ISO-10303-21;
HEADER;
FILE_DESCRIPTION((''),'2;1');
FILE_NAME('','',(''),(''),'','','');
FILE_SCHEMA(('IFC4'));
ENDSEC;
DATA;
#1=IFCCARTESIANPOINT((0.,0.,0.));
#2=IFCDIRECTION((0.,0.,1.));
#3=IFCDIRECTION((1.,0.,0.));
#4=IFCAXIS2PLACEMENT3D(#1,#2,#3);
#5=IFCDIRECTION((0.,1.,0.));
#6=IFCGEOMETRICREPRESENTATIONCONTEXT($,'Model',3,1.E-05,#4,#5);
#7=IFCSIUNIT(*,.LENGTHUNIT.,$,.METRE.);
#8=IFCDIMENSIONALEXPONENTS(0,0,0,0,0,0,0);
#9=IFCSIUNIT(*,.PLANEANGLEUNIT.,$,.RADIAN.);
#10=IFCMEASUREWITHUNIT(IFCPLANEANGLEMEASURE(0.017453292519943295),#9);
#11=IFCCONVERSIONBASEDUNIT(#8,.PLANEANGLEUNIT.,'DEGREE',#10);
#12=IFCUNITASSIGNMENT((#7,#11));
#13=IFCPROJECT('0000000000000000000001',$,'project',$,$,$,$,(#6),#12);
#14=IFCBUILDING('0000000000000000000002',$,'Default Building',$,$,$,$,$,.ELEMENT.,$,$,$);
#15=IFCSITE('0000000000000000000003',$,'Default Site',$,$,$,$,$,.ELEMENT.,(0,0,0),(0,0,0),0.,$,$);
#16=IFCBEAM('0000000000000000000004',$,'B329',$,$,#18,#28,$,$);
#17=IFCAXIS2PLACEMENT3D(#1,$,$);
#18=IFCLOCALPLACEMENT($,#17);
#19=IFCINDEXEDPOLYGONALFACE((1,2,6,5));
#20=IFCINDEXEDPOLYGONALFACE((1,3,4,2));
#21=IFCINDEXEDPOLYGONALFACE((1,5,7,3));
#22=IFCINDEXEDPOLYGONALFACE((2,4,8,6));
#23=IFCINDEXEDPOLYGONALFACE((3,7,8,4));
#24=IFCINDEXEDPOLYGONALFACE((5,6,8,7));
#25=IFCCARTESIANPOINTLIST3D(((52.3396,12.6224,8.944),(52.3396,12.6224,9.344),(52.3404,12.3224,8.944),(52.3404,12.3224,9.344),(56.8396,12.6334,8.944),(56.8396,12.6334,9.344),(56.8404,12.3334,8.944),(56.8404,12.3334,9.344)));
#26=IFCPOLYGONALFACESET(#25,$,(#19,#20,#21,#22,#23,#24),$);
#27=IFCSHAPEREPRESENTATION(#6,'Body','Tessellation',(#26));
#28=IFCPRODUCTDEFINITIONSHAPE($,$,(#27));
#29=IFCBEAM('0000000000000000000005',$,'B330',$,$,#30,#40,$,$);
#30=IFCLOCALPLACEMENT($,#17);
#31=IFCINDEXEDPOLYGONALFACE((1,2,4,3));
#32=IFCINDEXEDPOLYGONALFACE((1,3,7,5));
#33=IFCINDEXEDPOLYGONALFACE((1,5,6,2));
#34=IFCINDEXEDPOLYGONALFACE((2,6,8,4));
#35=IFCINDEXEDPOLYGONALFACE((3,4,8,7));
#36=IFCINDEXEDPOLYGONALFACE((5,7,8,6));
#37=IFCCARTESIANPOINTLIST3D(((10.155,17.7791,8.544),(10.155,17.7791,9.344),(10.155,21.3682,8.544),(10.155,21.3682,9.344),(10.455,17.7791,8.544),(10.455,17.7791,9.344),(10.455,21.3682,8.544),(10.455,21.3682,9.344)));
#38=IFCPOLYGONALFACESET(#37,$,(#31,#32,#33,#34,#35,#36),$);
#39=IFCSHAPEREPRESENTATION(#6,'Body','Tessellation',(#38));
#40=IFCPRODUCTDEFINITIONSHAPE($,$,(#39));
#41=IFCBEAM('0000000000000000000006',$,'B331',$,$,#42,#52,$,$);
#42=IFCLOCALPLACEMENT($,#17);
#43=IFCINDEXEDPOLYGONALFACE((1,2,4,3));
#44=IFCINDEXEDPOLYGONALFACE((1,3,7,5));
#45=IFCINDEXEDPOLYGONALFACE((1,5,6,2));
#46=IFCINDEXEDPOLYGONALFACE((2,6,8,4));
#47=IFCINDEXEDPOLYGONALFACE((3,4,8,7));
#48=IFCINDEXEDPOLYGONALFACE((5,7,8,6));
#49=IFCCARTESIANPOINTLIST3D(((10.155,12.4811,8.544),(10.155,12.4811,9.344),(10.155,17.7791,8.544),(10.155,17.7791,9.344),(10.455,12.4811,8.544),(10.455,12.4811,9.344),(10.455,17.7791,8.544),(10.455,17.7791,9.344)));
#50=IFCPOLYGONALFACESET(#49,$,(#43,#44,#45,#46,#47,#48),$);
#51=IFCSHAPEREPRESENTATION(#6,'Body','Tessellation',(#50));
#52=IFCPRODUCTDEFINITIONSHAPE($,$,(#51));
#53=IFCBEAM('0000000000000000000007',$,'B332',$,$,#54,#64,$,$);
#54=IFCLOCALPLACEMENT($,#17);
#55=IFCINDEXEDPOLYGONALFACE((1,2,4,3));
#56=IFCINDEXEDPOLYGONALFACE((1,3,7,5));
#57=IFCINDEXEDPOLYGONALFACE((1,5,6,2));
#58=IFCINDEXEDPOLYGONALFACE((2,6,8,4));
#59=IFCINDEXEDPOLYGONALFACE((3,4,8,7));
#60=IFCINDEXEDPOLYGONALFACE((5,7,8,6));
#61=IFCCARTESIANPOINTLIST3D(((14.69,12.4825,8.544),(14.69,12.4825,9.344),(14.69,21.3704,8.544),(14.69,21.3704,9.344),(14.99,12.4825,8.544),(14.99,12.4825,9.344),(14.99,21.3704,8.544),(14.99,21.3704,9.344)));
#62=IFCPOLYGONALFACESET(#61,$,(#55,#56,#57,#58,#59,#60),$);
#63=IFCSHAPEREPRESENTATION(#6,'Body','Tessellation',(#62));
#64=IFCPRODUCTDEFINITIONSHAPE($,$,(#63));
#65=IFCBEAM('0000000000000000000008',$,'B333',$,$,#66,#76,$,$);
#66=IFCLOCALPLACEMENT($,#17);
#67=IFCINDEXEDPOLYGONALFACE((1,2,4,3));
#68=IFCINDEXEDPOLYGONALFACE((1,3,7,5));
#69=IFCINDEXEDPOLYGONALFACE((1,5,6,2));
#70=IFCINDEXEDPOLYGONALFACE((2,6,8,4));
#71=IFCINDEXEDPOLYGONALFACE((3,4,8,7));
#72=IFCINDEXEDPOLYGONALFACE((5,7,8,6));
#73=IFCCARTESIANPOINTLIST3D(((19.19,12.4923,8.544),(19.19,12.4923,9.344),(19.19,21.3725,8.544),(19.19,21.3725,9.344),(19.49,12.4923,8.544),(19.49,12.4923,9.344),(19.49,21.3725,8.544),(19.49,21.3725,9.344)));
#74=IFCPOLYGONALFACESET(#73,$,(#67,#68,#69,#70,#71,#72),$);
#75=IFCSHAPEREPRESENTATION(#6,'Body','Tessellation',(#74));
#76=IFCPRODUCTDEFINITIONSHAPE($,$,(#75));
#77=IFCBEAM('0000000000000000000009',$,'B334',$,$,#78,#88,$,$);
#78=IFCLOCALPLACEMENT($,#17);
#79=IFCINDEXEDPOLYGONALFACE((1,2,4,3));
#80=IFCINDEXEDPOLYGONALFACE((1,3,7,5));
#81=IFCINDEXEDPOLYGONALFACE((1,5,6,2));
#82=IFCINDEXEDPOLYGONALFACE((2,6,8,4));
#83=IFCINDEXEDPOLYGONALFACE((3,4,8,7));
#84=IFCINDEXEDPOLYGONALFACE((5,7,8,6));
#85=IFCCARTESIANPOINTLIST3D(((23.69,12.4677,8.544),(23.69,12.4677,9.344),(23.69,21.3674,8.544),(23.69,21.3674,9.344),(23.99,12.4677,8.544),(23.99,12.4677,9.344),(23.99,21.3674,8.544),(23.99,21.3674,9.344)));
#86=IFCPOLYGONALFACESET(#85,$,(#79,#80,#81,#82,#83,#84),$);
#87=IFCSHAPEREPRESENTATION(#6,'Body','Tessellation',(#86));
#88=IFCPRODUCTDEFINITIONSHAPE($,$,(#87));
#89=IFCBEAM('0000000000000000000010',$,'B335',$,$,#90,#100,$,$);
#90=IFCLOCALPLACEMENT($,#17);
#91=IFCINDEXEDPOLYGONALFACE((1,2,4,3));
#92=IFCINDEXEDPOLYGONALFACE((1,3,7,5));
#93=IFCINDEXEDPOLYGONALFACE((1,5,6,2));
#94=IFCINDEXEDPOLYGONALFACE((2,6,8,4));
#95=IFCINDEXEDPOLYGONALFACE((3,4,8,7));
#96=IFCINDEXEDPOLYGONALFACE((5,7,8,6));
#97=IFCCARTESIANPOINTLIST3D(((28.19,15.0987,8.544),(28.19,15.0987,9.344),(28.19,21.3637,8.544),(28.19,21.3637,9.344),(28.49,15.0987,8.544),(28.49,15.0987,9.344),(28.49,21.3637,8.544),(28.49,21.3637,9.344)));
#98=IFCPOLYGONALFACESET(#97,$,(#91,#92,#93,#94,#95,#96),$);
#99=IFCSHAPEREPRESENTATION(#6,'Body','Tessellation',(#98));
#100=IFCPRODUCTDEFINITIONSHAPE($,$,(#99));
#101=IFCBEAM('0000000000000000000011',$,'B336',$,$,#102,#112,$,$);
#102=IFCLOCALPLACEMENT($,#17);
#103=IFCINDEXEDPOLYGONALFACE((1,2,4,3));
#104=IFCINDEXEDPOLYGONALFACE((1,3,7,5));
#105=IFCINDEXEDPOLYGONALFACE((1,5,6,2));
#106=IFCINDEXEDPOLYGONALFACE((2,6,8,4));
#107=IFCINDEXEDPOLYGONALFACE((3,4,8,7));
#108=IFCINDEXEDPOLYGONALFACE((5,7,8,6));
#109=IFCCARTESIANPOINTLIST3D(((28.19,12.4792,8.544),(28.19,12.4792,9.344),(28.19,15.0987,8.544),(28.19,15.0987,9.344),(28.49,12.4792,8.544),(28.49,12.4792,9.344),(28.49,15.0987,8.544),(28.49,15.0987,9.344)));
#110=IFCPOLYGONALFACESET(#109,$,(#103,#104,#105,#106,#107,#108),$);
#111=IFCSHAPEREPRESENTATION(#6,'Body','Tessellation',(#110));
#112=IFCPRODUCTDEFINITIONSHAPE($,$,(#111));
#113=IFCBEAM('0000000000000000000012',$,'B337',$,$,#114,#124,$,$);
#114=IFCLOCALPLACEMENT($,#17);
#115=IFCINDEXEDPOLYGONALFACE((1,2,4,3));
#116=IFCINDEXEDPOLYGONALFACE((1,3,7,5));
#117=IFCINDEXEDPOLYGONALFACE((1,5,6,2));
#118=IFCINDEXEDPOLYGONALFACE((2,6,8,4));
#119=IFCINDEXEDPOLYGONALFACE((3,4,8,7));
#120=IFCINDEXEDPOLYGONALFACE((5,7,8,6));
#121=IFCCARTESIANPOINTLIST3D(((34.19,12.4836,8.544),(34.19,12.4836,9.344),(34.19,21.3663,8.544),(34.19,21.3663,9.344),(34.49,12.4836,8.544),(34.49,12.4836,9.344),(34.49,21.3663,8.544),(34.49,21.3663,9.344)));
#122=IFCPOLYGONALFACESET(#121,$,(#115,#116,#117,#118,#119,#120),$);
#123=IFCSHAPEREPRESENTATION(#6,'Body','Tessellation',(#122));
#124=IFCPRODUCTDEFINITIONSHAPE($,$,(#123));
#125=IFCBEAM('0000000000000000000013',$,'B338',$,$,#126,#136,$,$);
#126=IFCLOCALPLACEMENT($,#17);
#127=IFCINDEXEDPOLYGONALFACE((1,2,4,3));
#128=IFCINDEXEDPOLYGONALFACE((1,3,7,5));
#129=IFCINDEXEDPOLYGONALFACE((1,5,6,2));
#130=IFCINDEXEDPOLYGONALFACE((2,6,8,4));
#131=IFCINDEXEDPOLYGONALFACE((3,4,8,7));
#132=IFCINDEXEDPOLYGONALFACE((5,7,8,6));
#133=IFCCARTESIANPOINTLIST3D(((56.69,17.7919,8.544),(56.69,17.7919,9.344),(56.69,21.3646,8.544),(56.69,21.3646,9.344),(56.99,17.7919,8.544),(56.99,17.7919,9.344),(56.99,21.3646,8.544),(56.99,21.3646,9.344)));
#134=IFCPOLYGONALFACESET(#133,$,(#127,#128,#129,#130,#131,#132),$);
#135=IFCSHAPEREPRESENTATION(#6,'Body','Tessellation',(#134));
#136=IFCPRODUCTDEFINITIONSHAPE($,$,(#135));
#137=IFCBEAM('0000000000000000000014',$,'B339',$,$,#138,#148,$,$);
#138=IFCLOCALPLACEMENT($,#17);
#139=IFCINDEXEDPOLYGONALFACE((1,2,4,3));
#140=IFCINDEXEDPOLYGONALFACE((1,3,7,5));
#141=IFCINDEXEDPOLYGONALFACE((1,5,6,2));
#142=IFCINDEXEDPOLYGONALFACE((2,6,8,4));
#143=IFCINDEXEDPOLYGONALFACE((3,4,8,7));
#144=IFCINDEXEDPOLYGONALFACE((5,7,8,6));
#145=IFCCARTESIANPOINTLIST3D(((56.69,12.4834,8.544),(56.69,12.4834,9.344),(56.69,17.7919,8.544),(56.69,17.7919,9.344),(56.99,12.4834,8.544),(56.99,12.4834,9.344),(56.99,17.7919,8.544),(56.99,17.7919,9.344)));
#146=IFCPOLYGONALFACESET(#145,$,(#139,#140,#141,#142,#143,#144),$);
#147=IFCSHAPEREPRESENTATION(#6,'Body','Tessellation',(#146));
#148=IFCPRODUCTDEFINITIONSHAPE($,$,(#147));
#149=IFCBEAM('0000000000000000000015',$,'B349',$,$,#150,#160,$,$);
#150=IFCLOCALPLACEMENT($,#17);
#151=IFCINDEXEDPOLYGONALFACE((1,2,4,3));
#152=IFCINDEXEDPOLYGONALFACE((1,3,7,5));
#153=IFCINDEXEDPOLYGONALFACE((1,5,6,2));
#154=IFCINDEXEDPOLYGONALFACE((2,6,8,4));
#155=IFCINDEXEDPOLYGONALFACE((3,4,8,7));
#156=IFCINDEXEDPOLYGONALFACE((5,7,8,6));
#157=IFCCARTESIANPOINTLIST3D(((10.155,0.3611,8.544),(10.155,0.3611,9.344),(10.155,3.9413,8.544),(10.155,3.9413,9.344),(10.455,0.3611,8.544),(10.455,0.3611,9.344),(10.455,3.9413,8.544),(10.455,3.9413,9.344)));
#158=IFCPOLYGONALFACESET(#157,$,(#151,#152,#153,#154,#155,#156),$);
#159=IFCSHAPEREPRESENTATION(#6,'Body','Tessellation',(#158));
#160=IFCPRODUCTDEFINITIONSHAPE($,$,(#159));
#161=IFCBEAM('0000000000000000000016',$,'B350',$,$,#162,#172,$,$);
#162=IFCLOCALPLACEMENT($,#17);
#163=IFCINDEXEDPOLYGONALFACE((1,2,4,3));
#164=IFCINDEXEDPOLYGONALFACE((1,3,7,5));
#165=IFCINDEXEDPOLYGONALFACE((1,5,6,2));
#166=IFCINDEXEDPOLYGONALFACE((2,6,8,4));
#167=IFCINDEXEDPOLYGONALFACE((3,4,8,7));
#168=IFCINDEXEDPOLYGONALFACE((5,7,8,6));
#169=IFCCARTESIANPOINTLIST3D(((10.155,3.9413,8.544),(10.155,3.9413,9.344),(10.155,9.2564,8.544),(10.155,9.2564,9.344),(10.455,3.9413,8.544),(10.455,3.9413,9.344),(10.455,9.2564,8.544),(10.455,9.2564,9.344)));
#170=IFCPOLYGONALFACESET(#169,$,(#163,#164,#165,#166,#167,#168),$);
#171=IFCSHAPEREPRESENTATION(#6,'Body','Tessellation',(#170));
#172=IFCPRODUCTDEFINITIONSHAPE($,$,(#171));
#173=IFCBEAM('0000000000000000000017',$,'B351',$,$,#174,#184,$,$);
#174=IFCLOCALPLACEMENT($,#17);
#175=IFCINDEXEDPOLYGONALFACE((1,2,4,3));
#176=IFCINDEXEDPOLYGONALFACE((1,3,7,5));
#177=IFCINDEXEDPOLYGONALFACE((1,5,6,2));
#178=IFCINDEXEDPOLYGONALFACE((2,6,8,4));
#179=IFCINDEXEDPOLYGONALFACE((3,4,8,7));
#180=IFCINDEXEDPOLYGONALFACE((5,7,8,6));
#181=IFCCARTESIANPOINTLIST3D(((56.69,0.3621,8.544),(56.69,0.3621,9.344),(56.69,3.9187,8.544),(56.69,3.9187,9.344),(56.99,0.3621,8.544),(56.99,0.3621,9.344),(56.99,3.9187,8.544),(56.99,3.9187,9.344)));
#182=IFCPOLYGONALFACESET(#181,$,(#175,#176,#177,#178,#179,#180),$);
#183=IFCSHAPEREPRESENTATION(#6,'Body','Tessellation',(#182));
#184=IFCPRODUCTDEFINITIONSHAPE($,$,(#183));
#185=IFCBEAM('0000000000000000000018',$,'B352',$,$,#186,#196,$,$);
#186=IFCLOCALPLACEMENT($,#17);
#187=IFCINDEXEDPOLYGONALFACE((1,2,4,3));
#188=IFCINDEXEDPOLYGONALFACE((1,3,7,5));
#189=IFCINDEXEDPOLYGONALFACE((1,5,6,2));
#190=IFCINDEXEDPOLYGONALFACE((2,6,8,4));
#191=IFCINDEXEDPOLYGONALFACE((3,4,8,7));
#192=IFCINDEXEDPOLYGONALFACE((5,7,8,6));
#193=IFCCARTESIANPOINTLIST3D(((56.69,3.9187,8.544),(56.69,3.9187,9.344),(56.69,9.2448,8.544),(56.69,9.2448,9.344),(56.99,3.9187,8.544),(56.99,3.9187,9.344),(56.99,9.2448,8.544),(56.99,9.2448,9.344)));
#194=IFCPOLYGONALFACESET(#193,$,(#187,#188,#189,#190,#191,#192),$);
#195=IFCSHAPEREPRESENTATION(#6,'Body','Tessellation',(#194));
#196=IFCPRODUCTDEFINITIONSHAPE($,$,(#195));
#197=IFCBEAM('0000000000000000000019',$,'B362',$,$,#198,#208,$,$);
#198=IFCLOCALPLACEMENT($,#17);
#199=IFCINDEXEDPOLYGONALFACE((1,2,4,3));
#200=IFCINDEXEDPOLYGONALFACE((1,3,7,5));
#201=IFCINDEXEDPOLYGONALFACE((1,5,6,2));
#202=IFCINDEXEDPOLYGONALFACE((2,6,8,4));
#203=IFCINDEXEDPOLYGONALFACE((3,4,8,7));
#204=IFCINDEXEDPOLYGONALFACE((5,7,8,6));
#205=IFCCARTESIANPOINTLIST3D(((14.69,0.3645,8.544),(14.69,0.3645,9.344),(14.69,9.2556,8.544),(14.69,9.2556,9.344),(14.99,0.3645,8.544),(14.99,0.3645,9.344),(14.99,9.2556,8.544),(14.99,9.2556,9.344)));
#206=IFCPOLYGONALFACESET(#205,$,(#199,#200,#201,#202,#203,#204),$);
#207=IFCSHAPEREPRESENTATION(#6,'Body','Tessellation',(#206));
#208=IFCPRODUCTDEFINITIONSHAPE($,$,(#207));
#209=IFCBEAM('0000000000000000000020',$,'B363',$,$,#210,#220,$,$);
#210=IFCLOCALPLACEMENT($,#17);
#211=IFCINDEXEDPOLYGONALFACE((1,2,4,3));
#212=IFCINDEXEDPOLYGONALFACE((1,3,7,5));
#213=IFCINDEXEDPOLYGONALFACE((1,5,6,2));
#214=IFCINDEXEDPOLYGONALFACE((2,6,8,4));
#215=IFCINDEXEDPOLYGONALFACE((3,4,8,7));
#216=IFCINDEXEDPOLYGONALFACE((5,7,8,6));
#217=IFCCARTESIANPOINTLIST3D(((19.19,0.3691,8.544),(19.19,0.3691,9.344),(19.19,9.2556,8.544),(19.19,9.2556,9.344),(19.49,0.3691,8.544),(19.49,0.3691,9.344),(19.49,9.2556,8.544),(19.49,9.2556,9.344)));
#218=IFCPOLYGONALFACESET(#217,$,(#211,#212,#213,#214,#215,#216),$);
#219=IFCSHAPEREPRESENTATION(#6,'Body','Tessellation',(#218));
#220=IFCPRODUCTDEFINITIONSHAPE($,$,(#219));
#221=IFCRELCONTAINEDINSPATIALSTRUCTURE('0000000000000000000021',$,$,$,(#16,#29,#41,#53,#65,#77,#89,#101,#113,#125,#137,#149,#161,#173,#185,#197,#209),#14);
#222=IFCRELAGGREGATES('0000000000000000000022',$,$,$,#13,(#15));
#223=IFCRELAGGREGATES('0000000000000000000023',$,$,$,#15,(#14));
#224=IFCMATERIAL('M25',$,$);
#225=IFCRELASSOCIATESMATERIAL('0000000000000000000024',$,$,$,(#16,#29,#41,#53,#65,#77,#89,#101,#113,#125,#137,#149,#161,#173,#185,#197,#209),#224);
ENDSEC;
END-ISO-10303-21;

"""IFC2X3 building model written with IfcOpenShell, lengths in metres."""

from ifc_helpers import new_model, entity, si_unit, converted_unit, direction, frame, frame_2d, origin_with_axes, place, context, project, spatial, rectangle, extrude, material, element, save


model = new_model("IFC2X3")

# Units and contexts
model_context = context("Model", 3, precision=1e-05, world=origin_with_axes(), true_north=direction((0.0, 1.0, 0.0)))
ifc_project = project(units=[si_unit("LENGTHUNIT", "METRE"), converted_unit("PLANEANGLEUNIT", "DEGREE", entity("IfcPlaneAngleMeasure", 0.017453292519943295), si_unit("PLANEANGLEUNIT", "RADIAN"), dimensions=[0, 0, 0, 0, 0, 0, 0])], contexts=[model_context])

# Site, building
site = spatial("IfcSite", under=ifc_project, Name="Default Site", CompositionType="ELEMENT", RefLatitude=(0, 0, 0), RefLongitude=(0, 0, 0), RefElevation=0.0)
building = spatial("IfcBuilding", under=site, Name="Default Building", CompositionType="ELEMENT")

# Beams
ifc_material = material(Name="M25")
placement = place(None, origin_with_axes())
element("IfcBeam", 1, at=placement, inside=building, material=ifc_material, Name="B329", context=model_context, shape_type="SweptSolid", body=[
    extrude(rectangle(XDim=0.3, YDim=0.4, at=frame_2d((0.0, 0.0), x_axis=(0.0, 1.0, 0.0))), frame((52.34, 12.4724, 9.144), z_axis=(0.999997, 0.002456, 0.0), x_axis=(0.0, 0.0, -1.0)), (0.0, 0.0, 1.0), 4.5),
])
element("IfcBeam", 2, at=placement, inside=building, material=ifc_material, Name="B330", context=model_context, shape_type="SweptSolid", body=[
    extrude(rectangle(XDim=0.3, YDim=0.8, at=frame_2d((0.0, 0.0), x_axis=(0.0, 1.0, 0.0))), frame((10.305, 21.3682, 8.944), z_axis=(0.0, -1.0, 0.0), x_axis=(0.0, 0.0, -1.0)), (0.0, 0.0, 1.0), 3.5891),
])
element("IfcBeam", 3, at=placement, inside=building, material=ifc_material, Name="B331", context=model_context, shape_type="SweptSolid", body=[
    extrude(rectangle(XDim=0.3, YDim=0.8, at=frame_2d((0.0, 0.0), x_axis=(0.0, 1.0, 0.0))), frame((10.305, 17.7791, 8.944), z_axis=(0.0, -1.0, 0.0), x_axis=(0.0, 0.0, -1.0)), (0.0, 0.0, 1.0), 5.298),
])
element("IfcBeam", 4, at=placement, inside=building, material=ifc_material, Name="B332", context=model_context, shape_type="SweptSolid", body=[
    extrude(rectangle(XDim=0.3, YDim=0.8, at=frame_2d((0.0, 0.0), x_axis=(0.0, 1.0, 0.0))), frame((14.84, 21.3704, 8.944), z_axis=(0.0, -1.0, 0.0), x_axis=(0.0, 0.0, -1.0)), (0.0, 0.0, 1.0), 8.8879),
])
element("IfcBeam", 5, at=placement, inside=building, material=ifc_material, Name="B333", context=model_context, shape_type="SweptSolid", body=[
    extrude(rectangle(XDim=0.3, YDim=0.8, at=frame_2d((0.0, 0.0), x_axis=(0.0, 1.0, 0.0))), frame((19.34, 21.3725, 8.944), z_axis=(0.0, -1.0, 0.0), x_axis=(0.0, 0.0, -1.0)), (0.0, 0.0, 1.0), 8.8802),
])
element("IfcBeam", 6, at=placement, inside=building, material=ifc_material, Name="B334", context=model_context, shape_type="SweptSolid", body=[
    extrude(rectangle(XDim=0.3, YDim=0.8, at=frame_2d((0.0, 0.0), x_axis=(0.0, 1.0, 0.0))), frame((23.84, 21.3674, 8.944), z_axis=(0.0, -1.0, 0.0), x_axis=(0.0, 0.0, -1.0)), (0.0, 0.0, 1.0), 8.8997),
])
element("IfcBeam", 7, at=placement, inside=building, material=ifc_material, Name="B335", context=model_context, shape_type="SweptSolid", body=[
    extrude(rectangle(XDim=0.3, YDim=0.8, at=frame_2d((0.0, 0.0), x_axis=(0.0, 1.0, 0.0))), frame((28.34, 21.3637, 8.944), z_axis=(0.0, -1.0, 0.0), x_axis=(0.0, 0.0, -1.0)), (0.0, 0.0, 1.0), 6.265),
])
element("IfcBeam", 8, at=placement, inside=building, material=ifc_material, Name="B336", context=model_context, shape_type="SweptSolid", body=[
    extrude(rectangle(XDim=0.3, YDim=0.8, at=frame_2d((0.0, 0.0), x_axis=(0.0, 1.0, 0.0))), frame((28.34, 15.0987, 8.944), z_axis=(0.0, -1.0, 0.0), x_axis=(0.0, 0.0, -1.0)), (0.0, 0.0, 1.0), 2.6195),
])
element("IfcBeam", 9, at=placement, inside=building, material=ifc_material, Name="B337", context=model_context, shape_type="SweptSolid", body=[
    extrude(rectangle(XDim=0.3, YDim=0.8, at=frame_2d((0.0, 0.0), x_axis=(0.0, 1.0, 0.0))), frame((34.34, 12.4836, 8.944), z_axis=(0.0, 1.0, 0.0), x_axis=(0.0, 0.0, -1.0)), (0.0, 0.0, 1.0), 8.8827),
])
element("IfcBeam", 10, at=placement, inside=building, material=ifc_material, Name="B338", context=model_context, shape_type="SweptSolid", body=[
    extrude(rectangle(XDim=0.3, YDim=0.8, at=frame_2d((0.0, 0.0), x_axis=(0.0, 1.0, 0.0))), frame((56.84, 17.7919, 8.944), z_axis=(0.0, 1.0, 0.0), x_axis=(0.0, 0.0, -1.0)), (0.0, 0.0, 1.0), 3.5727),
])
element("IfcBeam", 11, at=placement, inside=building, material=ifc_material, Name="B339", context=model_context, shape_type="SweptSolid", body=[
    extrude(rectangle(XDim=0.3, YDim=0.8, at=frame_2d((0.0, 0.0), x_axis=(0.0, 1.0, 0.0))), frame((56.84, 12.4834, 8.944), z_axis=(0.0, 1.0, 0.0), x_axis=(0.0, 0.0, -1.0)), (0.0, 0.0, 1.0), 5.3085),
])
element("IfcBeam", 12, at=placement, inside=building, material=ifc_material, Name="B349", context=model_context, shape_type="SweptSolid", body=[
    extrude(rectangle(XDim=0.3, YDim=0.8, at=frame_2d((0.0, 0.0), x_axis=(0.0, 1.0, 0.0))), frame((10.305, 3.9413, 8.944), z_axis=(0.0, -1.0, 0.0), x_axis=(0.0, 0.0, -1.0)), (0.0, 0.0, 1.0), 3.5802),
])
element("IfcBeam", 13, at=placement, inside=building, material=ifc_material, Name="B350", context=model_context, shape_type="SweptSolid", body=[
    extrude(rectangle(XDim=0.3, YDim=0.8, at=frame_2d((0.0, 0.0), x_axis=(0.0, 1.0, 0.0))), frame((10.305, 3.9413, 8.944), z_axis=(0.0, 1.0, 0.0), x_axis=(0.0, 0.0, -1.0)), (0.0, 0.0, 1.0), 5.3151),
])
element("IfcBeam", 14, at=placement, inside=building, material=ifc_material, Name="B351", context=model_context, shape_type="SweptSolid", body=[
    extrude(rectangle(XDim=0.3, YDim=0.8, at=frame_2d((0.0, 0.0), x_axis=(0.0, 1.0, 0.0))), frame((56.84, 0.3621, 8.944), z_axis=(0.0, 1.0, 0.0), x_axis=(0.0, 0.0, -1.0)), (0.0, 0.0, 1.0), 3.5566),
])
element("IfcBeam", 15, at=placement, inside=building, material=ifc_material, Name="B352", context=model_context, shape_type="SweptSolid", body=[
    extrude(rectangle(XDim=0.3, YDim=0.8, at=frame_2d((0.0, 0.0), x_axis=(0.0, 1.0, 0.0))), frame((56.84, 3.9187, 8.944), z_axis=(0.0, 1.0, 0.0), x_axis=(0.0, 0.0, -1.0)), (0.0, 0.0, 1.0), 5.3261),
])
element("IfcBeam", 16, at=placement, inside=building, material=ifc_material, Name="B362", context=model_context, shape_type="SweptSolid", body=[
    extrude(rectangle(XDim=0.3, YDim=0.8, at=frame_2d((0.0, 0.0), x_axis=(0.0, 1.0, 0.0))), frame((14.84, 0.3645, 8.944), z_axis=(0.0, 1.0, 0.0), x_axis=(0.0, 0.0, -1.0)), (0.0, 0.0, 1.0), 8.891),
])
element("IfcBeam", 17, at=placement, inside=building, material=ifc_material, Name="B363", context=model_context, shape_type="SweptSolid", body=[
    extrude(rectangle(XDim=0.3, YDim=0.8, at=frame_2d((0.0, 0.0), x_axis=(0.0, 1.0, 0.0))), frame((19.34, 0.3691, 8.944), z_axis=(0.0, 1.0, 0.0), x_axis=(0.0, 0.0, -1.0)), (0.0, 0.0, 1.0), 8.8865),
])

save(model, "model.ifc")
